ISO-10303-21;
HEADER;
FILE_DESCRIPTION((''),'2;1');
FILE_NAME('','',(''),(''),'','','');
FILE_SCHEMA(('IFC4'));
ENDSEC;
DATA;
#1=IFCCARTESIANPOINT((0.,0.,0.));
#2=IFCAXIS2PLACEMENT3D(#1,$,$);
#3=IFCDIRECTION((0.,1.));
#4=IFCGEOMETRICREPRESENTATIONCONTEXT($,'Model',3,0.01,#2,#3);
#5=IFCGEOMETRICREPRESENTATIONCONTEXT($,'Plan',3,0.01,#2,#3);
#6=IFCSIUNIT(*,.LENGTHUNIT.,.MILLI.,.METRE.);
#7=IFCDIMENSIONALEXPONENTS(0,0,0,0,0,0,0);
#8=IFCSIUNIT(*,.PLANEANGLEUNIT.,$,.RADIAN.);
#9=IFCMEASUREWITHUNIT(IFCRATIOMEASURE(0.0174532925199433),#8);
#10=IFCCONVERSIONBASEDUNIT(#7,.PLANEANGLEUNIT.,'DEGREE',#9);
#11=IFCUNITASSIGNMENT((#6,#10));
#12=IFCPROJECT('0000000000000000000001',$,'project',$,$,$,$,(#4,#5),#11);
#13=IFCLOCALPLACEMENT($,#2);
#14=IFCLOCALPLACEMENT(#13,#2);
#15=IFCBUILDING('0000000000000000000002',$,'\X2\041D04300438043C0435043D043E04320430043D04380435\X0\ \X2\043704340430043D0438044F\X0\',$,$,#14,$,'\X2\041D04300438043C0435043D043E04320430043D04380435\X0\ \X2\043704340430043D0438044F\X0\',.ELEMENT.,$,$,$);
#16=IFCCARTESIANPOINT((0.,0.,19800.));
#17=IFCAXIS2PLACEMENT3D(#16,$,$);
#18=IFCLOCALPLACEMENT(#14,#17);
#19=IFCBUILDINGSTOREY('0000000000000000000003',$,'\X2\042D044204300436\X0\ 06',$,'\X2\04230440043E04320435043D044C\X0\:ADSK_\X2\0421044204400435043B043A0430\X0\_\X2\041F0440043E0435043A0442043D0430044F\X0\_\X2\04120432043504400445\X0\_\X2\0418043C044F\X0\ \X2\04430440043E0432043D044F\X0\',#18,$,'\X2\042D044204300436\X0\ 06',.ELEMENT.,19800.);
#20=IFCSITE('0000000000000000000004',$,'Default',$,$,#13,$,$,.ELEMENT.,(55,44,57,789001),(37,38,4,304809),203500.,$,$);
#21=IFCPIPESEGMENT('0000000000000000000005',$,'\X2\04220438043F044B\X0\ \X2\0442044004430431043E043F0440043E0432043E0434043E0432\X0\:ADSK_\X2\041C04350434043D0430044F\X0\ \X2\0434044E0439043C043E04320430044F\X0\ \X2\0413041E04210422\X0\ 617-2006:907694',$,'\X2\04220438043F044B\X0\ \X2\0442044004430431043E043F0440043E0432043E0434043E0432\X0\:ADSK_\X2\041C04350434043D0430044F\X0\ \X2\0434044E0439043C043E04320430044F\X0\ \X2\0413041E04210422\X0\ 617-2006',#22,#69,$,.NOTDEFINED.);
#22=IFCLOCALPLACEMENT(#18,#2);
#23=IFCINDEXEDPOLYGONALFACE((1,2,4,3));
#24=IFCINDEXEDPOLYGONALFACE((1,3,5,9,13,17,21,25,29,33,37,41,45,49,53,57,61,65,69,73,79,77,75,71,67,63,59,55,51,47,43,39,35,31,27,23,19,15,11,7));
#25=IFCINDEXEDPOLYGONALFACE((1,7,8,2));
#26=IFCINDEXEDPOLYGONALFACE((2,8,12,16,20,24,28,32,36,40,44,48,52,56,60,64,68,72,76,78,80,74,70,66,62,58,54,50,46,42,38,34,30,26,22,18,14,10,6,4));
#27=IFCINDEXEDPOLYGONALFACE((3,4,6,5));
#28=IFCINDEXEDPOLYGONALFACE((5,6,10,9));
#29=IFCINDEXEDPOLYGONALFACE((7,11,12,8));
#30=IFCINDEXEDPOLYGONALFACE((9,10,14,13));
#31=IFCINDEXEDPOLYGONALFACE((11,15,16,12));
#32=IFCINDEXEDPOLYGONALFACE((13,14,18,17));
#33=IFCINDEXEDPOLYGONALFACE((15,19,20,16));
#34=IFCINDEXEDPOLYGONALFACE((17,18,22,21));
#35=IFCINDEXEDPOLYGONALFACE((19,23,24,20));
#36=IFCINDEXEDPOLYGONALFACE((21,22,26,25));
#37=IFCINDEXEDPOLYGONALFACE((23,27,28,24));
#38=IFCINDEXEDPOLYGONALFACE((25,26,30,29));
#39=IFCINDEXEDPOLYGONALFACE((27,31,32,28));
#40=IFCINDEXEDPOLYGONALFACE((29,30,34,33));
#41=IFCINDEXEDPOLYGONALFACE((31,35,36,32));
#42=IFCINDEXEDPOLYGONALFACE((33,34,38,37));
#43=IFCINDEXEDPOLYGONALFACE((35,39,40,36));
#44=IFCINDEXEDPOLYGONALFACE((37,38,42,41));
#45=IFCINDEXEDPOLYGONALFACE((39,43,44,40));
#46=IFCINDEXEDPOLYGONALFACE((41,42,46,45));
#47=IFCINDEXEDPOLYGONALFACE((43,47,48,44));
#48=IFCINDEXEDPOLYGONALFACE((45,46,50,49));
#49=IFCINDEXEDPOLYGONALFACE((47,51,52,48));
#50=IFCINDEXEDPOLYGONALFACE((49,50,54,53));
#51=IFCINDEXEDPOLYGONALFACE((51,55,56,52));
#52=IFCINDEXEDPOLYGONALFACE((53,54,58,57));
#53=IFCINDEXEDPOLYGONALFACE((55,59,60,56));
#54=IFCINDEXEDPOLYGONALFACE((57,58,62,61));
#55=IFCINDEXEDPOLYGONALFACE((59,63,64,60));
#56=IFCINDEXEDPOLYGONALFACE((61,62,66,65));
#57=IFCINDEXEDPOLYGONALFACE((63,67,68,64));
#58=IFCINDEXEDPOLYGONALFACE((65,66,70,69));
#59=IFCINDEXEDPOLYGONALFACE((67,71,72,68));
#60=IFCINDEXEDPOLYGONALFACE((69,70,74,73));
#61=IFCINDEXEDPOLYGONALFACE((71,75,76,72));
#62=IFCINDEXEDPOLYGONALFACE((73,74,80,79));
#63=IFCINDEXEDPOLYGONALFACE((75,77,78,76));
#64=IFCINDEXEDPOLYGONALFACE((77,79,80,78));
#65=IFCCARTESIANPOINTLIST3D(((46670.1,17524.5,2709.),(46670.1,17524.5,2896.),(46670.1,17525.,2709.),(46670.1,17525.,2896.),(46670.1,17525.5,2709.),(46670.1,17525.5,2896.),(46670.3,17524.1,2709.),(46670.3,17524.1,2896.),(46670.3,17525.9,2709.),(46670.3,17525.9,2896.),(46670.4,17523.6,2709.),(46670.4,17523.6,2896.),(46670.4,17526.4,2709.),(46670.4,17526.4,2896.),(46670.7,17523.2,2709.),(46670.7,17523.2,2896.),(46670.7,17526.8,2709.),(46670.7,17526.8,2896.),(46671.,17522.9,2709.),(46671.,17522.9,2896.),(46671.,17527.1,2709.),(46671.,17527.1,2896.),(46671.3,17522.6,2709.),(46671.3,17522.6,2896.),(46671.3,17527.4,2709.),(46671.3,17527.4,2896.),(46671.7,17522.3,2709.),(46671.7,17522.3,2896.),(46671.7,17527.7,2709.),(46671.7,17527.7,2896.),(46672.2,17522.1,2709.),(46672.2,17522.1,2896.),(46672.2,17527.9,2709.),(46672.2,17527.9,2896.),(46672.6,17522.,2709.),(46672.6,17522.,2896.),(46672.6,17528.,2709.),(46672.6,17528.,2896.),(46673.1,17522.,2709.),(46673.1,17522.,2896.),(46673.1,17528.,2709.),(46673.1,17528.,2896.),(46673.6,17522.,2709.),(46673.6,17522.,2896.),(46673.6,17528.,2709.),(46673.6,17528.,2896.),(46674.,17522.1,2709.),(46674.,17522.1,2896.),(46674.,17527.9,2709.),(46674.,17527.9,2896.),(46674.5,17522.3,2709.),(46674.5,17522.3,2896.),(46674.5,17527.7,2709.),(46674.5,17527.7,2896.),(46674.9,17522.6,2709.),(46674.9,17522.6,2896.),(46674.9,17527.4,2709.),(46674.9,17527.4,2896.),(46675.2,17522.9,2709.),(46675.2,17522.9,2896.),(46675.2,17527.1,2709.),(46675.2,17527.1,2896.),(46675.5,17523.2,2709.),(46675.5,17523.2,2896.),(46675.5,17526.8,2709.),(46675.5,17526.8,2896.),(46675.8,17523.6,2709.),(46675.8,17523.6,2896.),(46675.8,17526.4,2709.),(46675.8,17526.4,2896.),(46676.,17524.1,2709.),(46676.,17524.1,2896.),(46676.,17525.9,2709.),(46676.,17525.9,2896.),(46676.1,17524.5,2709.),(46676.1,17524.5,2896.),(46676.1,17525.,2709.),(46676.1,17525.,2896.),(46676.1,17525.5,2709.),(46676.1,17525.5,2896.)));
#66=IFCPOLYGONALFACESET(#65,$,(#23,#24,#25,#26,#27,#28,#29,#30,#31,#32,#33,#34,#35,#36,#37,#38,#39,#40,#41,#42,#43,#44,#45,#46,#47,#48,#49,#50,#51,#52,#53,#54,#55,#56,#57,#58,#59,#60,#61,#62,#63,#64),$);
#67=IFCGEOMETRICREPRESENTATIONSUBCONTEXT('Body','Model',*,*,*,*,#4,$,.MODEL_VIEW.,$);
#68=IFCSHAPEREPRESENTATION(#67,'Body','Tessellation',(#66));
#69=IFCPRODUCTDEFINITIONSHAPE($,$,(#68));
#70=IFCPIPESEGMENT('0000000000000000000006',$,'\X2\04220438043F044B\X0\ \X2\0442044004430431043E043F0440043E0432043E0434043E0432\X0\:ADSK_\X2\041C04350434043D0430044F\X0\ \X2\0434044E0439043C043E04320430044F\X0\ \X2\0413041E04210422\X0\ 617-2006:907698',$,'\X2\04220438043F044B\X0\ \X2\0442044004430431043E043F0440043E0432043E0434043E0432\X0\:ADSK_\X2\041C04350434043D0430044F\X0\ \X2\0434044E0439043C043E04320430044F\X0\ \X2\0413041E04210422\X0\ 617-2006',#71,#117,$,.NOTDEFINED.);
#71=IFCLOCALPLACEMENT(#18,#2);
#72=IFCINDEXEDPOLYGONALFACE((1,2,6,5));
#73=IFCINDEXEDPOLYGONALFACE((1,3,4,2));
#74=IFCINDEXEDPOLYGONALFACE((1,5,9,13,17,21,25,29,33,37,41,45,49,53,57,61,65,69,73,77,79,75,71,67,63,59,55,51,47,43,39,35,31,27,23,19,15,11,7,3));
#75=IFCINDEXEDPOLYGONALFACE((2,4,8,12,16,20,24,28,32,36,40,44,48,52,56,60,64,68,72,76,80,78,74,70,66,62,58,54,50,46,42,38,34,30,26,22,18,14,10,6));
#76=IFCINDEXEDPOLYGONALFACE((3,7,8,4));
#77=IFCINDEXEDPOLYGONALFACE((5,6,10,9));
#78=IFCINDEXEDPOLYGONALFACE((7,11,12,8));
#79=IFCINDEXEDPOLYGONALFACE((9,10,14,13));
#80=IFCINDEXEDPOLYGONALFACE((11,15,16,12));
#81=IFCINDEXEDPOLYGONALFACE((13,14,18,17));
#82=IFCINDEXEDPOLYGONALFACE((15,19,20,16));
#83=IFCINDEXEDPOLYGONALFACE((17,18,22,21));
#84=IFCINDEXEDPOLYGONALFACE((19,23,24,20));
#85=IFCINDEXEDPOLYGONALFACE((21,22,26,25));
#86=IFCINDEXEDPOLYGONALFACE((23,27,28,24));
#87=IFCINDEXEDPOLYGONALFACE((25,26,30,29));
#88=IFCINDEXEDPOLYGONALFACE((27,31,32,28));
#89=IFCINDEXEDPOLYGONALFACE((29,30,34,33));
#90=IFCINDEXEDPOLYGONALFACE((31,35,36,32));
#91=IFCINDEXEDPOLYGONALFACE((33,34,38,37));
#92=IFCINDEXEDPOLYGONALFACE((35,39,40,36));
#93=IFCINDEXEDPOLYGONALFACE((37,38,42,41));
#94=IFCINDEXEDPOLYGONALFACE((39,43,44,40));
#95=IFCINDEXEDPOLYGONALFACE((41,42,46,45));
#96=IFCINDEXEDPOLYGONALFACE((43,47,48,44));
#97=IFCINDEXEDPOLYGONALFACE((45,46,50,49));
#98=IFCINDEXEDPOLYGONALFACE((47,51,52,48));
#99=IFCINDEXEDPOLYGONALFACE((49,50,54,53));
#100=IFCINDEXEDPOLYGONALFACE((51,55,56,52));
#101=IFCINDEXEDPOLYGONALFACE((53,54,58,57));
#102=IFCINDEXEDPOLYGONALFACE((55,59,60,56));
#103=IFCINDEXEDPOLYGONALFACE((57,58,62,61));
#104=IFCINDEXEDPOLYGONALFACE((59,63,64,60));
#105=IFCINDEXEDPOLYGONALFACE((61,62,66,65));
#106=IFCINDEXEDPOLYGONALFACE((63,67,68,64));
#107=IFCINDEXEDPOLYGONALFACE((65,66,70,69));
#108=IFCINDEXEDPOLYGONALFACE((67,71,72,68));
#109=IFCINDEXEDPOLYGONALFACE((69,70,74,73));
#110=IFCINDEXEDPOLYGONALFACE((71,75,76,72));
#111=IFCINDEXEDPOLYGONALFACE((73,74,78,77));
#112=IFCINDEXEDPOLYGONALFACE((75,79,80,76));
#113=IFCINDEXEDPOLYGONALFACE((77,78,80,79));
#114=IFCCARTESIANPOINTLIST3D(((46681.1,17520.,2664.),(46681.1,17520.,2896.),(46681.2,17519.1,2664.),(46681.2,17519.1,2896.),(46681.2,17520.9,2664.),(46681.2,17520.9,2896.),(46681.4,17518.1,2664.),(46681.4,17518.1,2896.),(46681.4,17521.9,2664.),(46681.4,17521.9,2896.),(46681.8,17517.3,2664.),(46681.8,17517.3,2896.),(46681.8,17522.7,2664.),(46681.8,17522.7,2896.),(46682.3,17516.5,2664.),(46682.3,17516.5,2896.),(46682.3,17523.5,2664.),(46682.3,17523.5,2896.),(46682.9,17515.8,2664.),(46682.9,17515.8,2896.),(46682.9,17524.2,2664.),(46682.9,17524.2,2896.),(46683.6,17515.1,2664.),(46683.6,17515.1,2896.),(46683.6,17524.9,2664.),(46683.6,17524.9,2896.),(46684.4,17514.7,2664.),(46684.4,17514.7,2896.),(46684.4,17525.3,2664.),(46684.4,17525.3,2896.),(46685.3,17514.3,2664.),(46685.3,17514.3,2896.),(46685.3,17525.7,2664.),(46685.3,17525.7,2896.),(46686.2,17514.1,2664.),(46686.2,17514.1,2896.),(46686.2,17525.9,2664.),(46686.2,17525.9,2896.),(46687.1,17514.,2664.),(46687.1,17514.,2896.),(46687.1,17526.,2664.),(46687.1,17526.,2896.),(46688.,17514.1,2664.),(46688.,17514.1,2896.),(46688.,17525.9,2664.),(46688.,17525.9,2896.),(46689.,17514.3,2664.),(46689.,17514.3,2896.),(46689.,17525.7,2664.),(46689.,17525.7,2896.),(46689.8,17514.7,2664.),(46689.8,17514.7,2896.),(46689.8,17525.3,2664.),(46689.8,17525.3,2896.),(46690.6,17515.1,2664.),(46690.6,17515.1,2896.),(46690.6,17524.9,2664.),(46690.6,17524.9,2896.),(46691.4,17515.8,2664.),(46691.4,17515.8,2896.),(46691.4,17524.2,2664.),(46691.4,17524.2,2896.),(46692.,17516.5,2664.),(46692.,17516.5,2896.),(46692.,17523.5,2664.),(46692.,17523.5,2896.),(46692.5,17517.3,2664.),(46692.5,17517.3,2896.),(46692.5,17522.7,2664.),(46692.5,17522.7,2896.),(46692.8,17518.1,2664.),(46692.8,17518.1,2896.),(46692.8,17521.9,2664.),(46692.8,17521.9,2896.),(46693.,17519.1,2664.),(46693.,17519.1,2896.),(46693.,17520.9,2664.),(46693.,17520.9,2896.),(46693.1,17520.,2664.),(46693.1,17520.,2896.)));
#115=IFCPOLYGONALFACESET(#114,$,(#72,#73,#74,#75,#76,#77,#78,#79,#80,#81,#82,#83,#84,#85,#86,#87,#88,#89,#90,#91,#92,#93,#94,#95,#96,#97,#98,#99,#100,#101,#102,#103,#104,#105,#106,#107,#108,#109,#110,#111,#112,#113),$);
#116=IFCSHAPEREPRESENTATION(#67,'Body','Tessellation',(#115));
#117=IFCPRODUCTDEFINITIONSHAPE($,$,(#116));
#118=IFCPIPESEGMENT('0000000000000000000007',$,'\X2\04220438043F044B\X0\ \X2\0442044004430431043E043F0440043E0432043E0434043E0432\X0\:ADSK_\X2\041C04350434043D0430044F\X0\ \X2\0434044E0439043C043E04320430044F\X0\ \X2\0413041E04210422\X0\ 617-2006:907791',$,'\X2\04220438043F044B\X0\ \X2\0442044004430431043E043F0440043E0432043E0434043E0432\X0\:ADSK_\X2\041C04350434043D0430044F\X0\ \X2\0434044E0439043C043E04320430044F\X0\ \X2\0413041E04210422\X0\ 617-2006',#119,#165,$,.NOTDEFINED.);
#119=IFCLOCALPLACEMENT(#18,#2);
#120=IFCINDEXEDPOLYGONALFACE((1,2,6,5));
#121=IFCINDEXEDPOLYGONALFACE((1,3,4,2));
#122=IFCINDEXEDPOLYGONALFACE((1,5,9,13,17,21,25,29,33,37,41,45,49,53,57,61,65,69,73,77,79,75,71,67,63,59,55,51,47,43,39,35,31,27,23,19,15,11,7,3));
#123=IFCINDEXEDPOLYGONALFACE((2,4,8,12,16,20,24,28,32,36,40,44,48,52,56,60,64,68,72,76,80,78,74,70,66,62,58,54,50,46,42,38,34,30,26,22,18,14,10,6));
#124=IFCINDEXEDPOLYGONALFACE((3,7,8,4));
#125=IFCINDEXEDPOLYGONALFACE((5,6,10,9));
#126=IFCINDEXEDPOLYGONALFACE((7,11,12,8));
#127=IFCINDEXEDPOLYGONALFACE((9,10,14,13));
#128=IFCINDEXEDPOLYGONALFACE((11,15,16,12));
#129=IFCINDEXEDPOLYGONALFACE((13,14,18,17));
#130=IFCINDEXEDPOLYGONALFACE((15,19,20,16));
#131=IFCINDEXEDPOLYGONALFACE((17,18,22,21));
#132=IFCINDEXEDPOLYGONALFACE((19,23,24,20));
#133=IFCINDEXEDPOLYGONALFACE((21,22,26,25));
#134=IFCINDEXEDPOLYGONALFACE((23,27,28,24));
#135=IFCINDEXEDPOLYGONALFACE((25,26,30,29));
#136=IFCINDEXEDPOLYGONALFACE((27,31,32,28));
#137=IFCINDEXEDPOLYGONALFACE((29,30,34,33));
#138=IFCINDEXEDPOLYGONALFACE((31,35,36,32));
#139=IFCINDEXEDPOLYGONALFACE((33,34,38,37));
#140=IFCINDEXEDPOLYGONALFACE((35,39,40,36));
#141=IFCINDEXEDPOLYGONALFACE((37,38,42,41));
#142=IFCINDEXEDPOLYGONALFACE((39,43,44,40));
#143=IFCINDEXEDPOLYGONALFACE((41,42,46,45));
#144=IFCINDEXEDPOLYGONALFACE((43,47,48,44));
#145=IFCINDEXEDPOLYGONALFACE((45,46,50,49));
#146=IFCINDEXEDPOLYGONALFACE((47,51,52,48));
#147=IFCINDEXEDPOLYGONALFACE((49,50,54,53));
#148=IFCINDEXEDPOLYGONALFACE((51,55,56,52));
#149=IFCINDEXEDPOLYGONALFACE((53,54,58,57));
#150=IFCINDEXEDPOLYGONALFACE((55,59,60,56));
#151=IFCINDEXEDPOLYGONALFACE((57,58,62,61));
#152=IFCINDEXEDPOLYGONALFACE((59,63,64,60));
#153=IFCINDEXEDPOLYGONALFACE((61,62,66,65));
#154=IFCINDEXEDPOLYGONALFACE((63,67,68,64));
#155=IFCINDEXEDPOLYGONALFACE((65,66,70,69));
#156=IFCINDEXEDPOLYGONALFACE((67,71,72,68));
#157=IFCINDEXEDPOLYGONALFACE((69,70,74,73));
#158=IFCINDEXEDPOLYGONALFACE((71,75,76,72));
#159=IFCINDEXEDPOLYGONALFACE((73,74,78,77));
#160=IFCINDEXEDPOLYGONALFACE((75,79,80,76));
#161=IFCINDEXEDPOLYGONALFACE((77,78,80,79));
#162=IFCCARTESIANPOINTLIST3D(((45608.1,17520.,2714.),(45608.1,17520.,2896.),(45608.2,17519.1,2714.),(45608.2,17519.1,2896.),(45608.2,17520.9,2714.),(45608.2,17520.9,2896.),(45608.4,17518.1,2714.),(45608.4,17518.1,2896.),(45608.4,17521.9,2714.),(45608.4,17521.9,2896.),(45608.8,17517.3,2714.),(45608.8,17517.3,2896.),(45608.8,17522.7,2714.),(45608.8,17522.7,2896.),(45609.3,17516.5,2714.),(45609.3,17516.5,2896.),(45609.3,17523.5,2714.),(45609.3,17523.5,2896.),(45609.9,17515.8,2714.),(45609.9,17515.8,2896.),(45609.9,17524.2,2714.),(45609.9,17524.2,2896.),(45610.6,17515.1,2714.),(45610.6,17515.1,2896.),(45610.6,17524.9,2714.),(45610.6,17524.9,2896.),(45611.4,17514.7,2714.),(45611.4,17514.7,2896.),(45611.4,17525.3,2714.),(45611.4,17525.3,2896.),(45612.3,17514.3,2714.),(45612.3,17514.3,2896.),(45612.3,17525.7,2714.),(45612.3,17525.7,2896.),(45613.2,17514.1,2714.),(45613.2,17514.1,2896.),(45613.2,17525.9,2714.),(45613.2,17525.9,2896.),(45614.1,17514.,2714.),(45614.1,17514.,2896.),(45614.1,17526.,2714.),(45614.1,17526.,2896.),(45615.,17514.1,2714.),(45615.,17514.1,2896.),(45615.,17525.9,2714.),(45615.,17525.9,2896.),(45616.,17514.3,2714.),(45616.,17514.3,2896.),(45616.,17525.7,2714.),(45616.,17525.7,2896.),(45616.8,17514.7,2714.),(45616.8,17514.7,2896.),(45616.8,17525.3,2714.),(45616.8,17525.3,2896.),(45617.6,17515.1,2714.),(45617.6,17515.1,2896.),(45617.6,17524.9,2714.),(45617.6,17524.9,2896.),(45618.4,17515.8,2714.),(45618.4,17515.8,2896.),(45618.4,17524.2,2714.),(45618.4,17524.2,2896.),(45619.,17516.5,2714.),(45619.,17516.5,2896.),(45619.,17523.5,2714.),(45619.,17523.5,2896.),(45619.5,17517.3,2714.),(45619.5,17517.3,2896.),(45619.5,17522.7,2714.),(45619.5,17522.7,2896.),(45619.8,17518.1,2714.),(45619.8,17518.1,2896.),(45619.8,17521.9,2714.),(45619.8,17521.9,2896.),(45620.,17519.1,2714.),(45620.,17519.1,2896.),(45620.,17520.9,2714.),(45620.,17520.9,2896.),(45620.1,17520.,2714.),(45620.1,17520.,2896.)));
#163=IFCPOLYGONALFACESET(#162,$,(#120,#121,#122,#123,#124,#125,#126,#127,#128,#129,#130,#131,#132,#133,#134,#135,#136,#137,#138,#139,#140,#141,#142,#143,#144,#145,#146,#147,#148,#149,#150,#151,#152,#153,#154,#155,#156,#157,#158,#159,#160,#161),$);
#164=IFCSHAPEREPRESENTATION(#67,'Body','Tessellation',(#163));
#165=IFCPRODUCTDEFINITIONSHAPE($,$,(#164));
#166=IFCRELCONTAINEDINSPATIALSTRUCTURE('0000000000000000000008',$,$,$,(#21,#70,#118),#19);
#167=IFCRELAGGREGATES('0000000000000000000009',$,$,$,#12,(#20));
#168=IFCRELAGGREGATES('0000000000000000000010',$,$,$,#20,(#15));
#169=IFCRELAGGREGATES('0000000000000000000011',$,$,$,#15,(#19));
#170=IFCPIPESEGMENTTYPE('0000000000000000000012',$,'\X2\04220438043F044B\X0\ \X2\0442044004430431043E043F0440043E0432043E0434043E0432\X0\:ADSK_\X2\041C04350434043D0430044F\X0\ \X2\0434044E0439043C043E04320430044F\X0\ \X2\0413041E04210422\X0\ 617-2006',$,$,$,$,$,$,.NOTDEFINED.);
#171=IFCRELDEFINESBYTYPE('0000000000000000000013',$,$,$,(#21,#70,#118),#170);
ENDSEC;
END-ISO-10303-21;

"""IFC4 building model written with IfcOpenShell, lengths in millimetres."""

from ifc_helpers import new_model, entity, si_unit, converted_unit, direction, frame, origin, place, context, subcontext, project, spatial, indexed_curve, outline, extrude, type_object, element, save


model = new_model("IFC4")

# Units and contexts
model_context = context("Model", 3, precision=0.01, world=origin(), true_north=direction((0.0, 1.0)))
plan_context = context("Plan", 3, precision=0.01, world=origin(), true_north=direction((0.0, 1.0)))
body_context = subcontext(model_context, "Body", "Model", "MODEL_VIEW")
ifc_project = project(units=[si_unit("LENGTHUNIT", "METRE", prefix="MILLI"), converted_unit("PLANEANGLEUNIT", "DEGREE", entity("IfcRatioMeasure", 0.0174532925199433), si_unit("PLANEANGLEUNIT", "RADIAN"), dimensions=[0, 0, 0, 0, 0, 0, 0])], contexts=[model_context, plan_context])

# Site, building, storey
site_placement = place(None, origin())
site = spatial("IfcSite", under=ifc_project, at=site_placement, Name="Default", CompositionType="ELEMENT", RefLatitude=(55, 44, 57, 789001), RefLongitude=(37, 38, 4, 304809), RefElevation=203500.0)
building_placement = place(site_placement, origin())
building = spatial("IfcBuilding", under=site, at=building_placement, Name="Наименование здания", LongName="Наименование здания", CompositionType="ELEMENT")
storey_placement = place(building_placement, frame((0.0, 0.0, 19800.0)))
storey = spatial("IfcBuildingStorey", under=building, at=storey_placement, Name="Этаж 06", ObjectType="Уровень:ADSK_Стрелка_Проектная_Вверх_Имя уровня", LongName="Этаж 06", CompositionType="ELEMENT", Elevation=19800.0)

# Pipe segments
pipe_segment_type = type_object("IfcPipeSegmentType", Name="Типы трубопроводов:ADSK_Медная дюймовая ГОСТ 617-2006", PredefinedType="NOTDEFINED")
placement = place(storey_placement, origin())
element("IfcPipeSegment", 1, at=placement, inside=storey, type_object=pipe_segment_type, Name="Типы трубопроводов:ADSK_Медная дюймовая ГОСТ 617-2006:907694", ObjectType="Типы трубопроводов:ADSK_Медная дюймовая ГОСТ 617-2006", PredefinedType="NOTDEFINED", context=body_context, shape_type="SweptSolid", body=[
    extrude(outline(indexed_curve([(3.0, 0.0), (3.0, 0.5), (2.9, 0.9), (2.7, 1.4), (2.4, 1.8), (2.1, 2.1), (1.8, 2.4), (1.4, 2.7), (0.9, 2.9), (0.5, 3.0), (0.0, 3.0), (-0.5, 3.0), (-0.9, 2.9), (-1.4, 2.7), (-1.8, 2.4), (-2.1, 2.1), (-2.4, 1.8), (-2.7, 1.4), (-2.9, 0.9), (-3.0, 0.5), (-3.0, 0.0), (-3.0, -0.5), (-2.9, -0.9), (-2.7, -1.4), (-2.4, -1.8), (-2.1, -2.1), (-1.8, -2.4), (-1.4, -2.7), (-0.9, -2.9), (-0.5, -3.0), (0.0, -3.0), (0.5, -3.0), (0.9, -2.9), (1.4, -2.7), (1.8, -2.4), (2.1, -2.1), (2.4, -1.8), (2.7, -1.4), (2.9, -0.9), (3.0, -0.5), (3.0, 0.0)], self_intersect=False)), frame((46673.1, 17525.0, 2709.0), z_axis=(0.0, 0.0, 1.0), x_axis=(-1.0, 0.0, 0.0)), (0.0, 0.0, 1.0), 187.0),
])
element("IfcPipeSegment", 2, at=placement, inside=storey, type_object=pipe_segment_type, Name="Типы трубопроводов:ADSK_Медная дюймовая ГОСТ 617-2006:907698", ObjectType="Типы трубопроводов:ADSK_Медная дюймовая ГОСТ 617-2006", PredefinedType="NOTDEFINED", context=body_context, shape_type="SweptSolid", body=[
    extrude(outline(indexed_curve([(6.0, 0.0), (5.9, 0.9), (5.7, 1.9), (5.3, 2.7), (4.9, 3.5), (4.2, 4.2), (3.5, 4.9), (2.7, 5.3), (1.9, 5.7), (0.9, 5.9), (0.0, 6.0), (-0.9, 5.9), (-1.9, 5.7), (-2.7, 5.3), (-3.5, 4.9), (-4.2, 4.2), (-4.9, 3.5), (-5.3, 2.7), (-5.7, 1.9), (-5.9, 0.9), (-6.0, 0.0), (-5.9, -0.9), (-5.7, -1.9), (-5.3, -2.7), (-4.9, -3.5), (-4.2, -4.2), (-3.5, -4.9), (-2.7, -5.3), (-1.9, -5.7), (-0.9, -5.9), (0.0, -6.0), (0.9, -5.9), (1.9, -5.7), (2.7, -5.3), (3.5, -4.9), (4.2, -4.2), (4.9, -3.5), (5.3, -2.7), (5.7, -1.9), (5.9, -0.9), (6.0, 0.0)], self_intersect=False)), frame((46687.1, 17520.0, 2664.0), z_axis=(0.0, 0.0, 1.0), x_axis=(-1.0, 0.0, 0.0)), (0.0, 0.0, 1.0), 232.0),
])
element("IfcPipeSegment", 3, at=placement, inside=storey, type_object=pipe_segment_type, Name="Типы трубопроводов:ADSK_Медная дюймовая ГОСТ 617-2006:907791", ObjectType="Типы трубопроводов:ADSK_Медная дюймовая ГОСТ 617-2006", PredefinedType="NOTDEFINED", context=body_context, shape_type="SweptSolid", body=[
    extrude(outline(indexed_curve([(6.0, 0.0), (5.9, 0.9), (5.7, 1.9), (5.3, 2.7), (4.9, 3.5), (4.2, 4.2), (3.5, 4.9), (2.7, 5.3), (1.9, 5.7), (0.9, 5.9), (0.0, 6.0), (-0.9, 5.9), (-1.9, 5.7), (-2.7, 5.3), (-3.5, 4.9), (-4.2, 4.2), (-4.9, 3.5), (-5.3, 2.7), (-5.7, 1.9), (-5.9, 0.9), (-6.0, 0.0), (-5.9, -0.9), (-5.7, -1.9), (-5.3, -2.7), (-4.9, -3.5), (-4.2, -4.2), (-3.5, -4.9), (-2.7, -5.3), (-1.9, -5.7), (-0.9, -5.9), (0.0, -6.0), (0.9, -5.9), (1.9, -5.7), (2.7, -5.3), (3.5, -4.9), (4.2, -4.2), (4.9, -3.5), (5.3, -2.7), (5.7, -1.9), (5.9, -0.9), (6.0, 0.0)], self_intersect=False)), frame((45614.1, 17520.0, 2714.0), z_axis=(0.0, 0.0, 1.0), x_axis=(-1.0, 0.0, 0.0)), (0.0, 0.0, 1.0), 182.0),
])

save(model, "model.ifc")
